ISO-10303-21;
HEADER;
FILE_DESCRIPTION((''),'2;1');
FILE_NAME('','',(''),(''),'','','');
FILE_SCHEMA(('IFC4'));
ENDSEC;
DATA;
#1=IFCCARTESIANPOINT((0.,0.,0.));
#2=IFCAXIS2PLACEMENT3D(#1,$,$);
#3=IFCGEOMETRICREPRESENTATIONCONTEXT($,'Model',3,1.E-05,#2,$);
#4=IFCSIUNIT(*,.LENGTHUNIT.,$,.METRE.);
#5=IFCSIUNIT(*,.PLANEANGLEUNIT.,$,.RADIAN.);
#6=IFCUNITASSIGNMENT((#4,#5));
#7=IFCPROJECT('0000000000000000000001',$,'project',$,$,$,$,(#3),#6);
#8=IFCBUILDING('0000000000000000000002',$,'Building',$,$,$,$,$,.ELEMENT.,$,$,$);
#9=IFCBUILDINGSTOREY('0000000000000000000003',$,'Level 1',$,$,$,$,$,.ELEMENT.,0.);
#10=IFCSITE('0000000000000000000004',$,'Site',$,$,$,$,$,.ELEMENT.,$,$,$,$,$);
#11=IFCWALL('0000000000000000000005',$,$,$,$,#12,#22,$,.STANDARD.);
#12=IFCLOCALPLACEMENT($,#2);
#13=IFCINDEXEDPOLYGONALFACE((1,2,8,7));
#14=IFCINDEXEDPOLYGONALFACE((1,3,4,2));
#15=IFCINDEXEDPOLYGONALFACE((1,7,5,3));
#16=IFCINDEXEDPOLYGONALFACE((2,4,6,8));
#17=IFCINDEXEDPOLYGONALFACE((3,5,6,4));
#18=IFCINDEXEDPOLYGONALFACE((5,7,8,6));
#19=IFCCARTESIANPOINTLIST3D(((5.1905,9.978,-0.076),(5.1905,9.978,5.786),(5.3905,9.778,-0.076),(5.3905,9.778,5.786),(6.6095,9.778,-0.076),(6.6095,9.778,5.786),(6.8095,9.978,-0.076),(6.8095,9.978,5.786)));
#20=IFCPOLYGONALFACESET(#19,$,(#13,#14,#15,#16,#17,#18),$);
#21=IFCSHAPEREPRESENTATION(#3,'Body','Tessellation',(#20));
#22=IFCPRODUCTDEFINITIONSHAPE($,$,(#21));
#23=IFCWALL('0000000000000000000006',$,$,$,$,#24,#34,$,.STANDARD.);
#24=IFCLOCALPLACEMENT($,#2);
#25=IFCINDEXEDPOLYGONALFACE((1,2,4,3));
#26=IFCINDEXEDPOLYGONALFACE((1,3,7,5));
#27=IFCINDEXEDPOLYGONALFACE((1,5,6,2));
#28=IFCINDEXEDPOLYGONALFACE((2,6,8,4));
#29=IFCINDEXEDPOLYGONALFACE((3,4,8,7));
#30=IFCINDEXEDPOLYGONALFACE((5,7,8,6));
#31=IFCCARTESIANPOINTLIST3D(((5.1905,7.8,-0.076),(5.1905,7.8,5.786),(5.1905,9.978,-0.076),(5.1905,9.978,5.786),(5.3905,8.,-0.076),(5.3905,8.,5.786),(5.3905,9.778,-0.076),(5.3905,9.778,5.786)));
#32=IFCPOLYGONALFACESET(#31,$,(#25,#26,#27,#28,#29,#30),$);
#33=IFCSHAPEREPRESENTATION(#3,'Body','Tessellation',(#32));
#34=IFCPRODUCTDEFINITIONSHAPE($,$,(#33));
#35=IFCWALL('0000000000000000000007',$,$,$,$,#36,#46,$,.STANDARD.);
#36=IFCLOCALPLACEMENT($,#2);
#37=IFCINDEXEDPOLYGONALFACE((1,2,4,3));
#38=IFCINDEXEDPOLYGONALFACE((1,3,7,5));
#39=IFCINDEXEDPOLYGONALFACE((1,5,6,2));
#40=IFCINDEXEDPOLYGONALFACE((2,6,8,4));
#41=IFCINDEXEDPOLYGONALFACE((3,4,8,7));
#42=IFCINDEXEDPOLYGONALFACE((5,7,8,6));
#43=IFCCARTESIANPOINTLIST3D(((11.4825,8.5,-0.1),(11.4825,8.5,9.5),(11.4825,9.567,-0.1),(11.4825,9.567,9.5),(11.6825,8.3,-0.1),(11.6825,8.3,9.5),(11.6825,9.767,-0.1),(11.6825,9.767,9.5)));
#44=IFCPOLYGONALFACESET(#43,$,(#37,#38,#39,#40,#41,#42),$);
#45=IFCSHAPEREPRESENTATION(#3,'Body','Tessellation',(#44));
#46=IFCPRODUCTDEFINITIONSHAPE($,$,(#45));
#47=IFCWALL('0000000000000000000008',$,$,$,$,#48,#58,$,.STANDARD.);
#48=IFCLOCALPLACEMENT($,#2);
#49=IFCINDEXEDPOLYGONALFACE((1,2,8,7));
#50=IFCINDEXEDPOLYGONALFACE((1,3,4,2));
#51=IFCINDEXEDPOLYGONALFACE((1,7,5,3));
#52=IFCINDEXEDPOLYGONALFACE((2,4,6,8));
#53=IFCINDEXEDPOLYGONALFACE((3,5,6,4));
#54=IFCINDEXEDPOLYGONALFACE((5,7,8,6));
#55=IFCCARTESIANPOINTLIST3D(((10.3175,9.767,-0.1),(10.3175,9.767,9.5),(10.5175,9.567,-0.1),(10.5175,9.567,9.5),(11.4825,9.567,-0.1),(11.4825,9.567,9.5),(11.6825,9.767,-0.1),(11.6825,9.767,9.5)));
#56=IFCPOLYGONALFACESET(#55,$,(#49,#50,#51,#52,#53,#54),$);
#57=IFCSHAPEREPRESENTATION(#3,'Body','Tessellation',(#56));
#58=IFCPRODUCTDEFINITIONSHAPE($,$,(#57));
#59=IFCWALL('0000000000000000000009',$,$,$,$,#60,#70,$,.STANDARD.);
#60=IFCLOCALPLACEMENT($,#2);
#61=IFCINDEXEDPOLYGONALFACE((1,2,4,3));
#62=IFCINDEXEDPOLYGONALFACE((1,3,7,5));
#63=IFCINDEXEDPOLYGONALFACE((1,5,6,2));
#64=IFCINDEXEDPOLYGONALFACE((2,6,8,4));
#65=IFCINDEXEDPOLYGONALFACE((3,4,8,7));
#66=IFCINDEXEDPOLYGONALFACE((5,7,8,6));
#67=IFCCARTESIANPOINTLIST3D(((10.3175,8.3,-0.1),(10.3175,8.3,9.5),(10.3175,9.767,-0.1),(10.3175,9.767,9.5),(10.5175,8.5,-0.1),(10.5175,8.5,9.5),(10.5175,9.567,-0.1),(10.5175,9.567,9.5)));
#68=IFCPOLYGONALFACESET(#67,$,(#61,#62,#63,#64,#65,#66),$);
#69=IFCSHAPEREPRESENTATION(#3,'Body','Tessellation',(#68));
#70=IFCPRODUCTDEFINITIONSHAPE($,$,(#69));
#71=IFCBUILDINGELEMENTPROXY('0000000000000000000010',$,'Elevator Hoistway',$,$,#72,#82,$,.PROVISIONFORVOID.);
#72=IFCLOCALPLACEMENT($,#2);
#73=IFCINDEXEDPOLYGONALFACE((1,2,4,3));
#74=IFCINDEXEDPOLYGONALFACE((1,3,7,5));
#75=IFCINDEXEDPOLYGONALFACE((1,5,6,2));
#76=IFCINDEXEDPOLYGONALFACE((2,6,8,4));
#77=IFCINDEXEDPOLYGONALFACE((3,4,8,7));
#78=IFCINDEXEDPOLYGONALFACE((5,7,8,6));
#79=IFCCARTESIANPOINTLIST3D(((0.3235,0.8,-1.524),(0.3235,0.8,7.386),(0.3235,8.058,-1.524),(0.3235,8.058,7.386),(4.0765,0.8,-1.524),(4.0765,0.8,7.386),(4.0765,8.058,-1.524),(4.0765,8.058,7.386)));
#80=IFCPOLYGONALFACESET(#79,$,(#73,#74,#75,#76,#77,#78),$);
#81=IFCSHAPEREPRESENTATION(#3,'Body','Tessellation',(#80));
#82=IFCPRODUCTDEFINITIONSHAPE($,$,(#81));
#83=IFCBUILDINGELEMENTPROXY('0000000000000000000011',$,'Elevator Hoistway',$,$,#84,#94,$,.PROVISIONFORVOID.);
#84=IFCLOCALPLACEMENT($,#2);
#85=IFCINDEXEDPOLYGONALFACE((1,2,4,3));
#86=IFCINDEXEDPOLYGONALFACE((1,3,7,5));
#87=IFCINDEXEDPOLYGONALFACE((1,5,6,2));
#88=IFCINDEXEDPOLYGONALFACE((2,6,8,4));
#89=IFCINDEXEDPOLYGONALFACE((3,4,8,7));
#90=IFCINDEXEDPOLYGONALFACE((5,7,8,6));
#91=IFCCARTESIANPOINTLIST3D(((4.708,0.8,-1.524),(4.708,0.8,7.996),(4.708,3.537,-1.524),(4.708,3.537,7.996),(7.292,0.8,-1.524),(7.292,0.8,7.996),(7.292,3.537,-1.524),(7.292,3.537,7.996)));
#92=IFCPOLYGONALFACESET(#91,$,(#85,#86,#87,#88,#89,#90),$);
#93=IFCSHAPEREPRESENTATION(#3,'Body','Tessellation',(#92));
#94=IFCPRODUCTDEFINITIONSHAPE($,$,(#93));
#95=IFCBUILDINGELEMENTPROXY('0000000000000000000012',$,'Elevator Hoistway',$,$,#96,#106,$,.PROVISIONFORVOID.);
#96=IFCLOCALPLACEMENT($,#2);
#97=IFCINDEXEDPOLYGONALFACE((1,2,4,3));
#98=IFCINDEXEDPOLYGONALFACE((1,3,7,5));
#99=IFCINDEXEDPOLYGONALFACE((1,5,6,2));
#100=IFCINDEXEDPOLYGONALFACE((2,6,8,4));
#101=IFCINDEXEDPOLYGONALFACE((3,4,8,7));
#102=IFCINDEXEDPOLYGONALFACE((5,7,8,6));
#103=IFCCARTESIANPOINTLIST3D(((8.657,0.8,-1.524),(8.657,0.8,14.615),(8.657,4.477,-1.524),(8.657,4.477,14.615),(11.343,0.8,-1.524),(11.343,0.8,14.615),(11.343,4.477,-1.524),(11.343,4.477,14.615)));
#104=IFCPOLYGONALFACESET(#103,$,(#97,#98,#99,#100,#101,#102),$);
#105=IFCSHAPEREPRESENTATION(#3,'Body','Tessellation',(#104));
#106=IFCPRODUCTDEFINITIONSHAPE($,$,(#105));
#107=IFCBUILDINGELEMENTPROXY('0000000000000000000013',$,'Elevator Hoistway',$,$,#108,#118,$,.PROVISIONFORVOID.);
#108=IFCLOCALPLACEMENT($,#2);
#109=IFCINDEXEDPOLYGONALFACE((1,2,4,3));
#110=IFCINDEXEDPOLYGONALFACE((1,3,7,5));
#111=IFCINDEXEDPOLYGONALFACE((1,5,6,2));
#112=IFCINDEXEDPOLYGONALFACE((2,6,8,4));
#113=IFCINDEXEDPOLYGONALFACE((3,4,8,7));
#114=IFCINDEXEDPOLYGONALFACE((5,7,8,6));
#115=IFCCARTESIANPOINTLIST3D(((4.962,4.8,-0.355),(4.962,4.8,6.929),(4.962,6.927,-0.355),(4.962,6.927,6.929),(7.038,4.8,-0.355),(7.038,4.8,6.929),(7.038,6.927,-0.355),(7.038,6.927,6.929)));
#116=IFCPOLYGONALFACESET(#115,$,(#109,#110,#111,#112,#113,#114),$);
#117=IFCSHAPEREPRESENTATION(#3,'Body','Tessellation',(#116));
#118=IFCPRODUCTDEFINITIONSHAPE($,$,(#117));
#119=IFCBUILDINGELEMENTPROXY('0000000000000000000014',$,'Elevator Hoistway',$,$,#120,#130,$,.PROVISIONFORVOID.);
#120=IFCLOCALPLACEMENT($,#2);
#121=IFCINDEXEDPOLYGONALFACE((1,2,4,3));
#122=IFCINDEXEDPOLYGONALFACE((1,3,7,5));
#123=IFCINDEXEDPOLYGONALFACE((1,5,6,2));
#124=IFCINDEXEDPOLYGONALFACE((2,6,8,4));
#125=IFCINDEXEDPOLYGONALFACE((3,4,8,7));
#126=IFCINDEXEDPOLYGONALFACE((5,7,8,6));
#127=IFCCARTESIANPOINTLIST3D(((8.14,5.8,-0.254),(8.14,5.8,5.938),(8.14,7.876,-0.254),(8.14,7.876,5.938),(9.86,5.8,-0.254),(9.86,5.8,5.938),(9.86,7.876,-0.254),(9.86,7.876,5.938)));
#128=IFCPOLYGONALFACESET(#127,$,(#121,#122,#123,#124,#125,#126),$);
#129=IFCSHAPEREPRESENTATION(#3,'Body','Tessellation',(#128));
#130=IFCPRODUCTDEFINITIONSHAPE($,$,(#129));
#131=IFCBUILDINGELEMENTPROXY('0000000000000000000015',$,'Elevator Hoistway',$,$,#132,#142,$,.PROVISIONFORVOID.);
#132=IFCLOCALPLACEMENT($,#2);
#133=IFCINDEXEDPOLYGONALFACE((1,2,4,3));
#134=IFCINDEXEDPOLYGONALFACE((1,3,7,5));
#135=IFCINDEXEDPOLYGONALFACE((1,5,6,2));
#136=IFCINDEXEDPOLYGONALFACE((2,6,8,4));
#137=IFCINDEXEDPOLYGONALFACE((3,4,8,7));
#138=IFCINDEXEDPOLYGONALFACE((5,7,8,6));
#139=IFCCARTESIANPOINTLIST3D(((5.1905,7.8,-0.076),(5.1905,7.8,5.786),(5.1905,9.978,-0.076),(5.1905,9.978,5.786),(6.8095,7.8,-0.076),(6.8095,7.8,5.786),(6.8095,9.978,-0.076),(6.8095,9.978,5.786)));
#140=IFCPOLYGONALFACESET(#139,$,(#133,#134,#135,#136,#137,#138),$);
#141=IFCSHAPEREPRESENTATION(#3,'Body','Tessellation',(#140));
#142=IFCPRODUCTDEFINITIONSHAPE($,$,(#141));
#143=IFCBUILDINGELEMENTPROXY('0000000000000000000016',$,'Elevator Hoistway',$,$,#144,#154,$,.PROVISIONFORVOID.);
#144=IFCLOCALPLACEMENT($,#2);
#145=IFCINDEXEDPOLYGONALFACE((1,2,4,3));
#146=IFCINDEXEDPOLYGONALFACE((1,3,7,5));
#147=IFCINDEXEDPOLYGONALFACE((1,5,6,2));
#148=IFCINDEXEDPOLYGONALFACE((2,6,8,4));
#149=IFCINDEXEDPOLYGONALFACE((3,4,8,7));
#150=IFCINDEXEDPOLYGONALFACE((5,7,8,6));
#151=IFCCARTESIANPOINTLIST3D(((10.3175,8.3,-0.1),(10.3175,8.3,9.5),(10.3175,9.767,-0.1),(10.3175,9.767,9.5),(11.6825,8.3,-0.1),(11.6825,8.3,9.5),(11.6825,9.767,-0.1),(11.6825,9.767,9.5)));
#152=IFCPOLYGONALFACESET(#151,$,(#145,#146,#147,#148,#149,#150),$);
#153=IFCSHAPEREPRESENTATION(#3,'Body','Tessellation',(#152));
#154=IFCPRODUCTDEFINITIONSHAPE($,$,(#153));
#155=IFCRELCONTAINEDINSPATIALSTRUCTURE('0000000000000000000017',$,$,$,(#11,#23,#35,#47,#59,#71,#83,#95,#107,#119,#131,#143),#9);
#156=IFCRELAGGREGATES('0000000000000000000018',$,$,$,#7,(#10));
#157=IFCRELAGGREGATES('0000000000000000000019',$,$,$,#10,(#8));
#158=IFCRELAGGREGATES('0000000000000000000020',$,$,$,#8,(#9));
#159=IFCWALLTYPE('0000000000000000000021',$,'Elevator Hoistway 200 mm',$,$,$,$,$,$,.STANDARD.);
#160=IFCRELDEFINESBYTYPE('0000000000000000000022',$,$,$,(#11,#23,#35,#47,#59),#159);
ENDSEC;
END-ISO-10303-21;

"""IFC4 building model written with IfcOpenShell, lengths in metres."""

from ifc_helpers import new_model, si_unit, frame, origin, place, context, project, spatial, polyline, outline, extrude, type_object, element, save


model = new_model("IFC4")

# Units and contexts
model_context = context("Model", 3, precision=1e-05, world=origin())
ifc_project = project(units=[si_unit("LENGTHUNIT", "METRE"), si_unit("PLANEANGLEUNIT", "RADIAN")], contexts=[model_context])

# Site, building, storey
site = spatial("IfcSite", under=ifc_project, Name="Site", CompositionType="ELEMENT")
building = spatial("IfcBuilding", under=site, Name="Building", CompositionType="ELEMENT")
storey = spatial("IfcBuildingStorey", under=building, Name="Level 1", CompositionType="ELEMENT", Elevation=0.0)

# Shared definitions
wall_type = type_object("IfcWallType", Name="Elevator Hoistway 200 mm", PredefinedType="STANDARD")

# Walls
wall_1_placement = place(None, frame((6.7095, 9.878, -0.076), z_axis=(0.0, 0.0, 1.0), x_axis=(-1.0, 0.0, 0.0)))
element("IfcWall", 1, at=wall_1_placement, inside=storey, type_object=wall_type, PredefinedType="STANDARD", context=model_context, shape_type="SweptSolid", body=[
    extrude(outline(polyline([(-0.1, -0.1), (1.519, -0.1), (1.319, 0.1), (0.1, 0.1), (-0.1, -0.1)])), origin(), (0.0, 0.0, 1.0), 5.862),
])
wall_2_placement = place(None, frame((5.2905, 9.878, -0.076), z_axis=(0.0, 0.0, 1.0), x_axis=(0.0, -1.0, 0.0)))
element("IfcWall", 2, at=wall_2_placement, inside=storey, type_object=wall_type, PredefinedType="STANDARD", context=model_context, shape_type="SweptSolid", body=[
    extrude(outline(polyline([(-0.1, -0.1), (2.078, -0.1), (1.878, 0.1), (0.1, 0.1), (-0.1, -0.1)])), origin(), (0.0, 0.0, 1.0), 5.862),
])

# Walls
wall_3_placement = place(None, frame((11.5825, 8.4, -0.1), z_axis=(0.0, 0.0, 1.0), x_axis=(0.0, 1.0, 0.0)))
element("IfcWall", 3, at=wall_3_placement, inside=storey, type_object=wall_type, PredefinedType="STANDARD", context=model_context, shape_type="SweptSolid", body=[
    extrude(outline(polyline([(-0.1, -0.1), (1.367, -0.1), (1.167, 0.1), (0.1, 0.1), (-0.1, -0.1)])), origin(), (0.0, 0.0, 1.0), 9.6),
])
wall_4_placement = place(None, frame((11.5825, 9.667, -0.1), z_axis=(0.0, 0.0, 1.0), x_axis=(-1.0, 0.0, 0.0)))
element("IfcWall", 4, at=wall_4_placement, inside=storey, type_object=wall_type, PredefinedType="STANDARD", context=model_context, shape_type="SweptSolid", body=[
    extrude(outline(polyline([(-0.1, -0.1), (1.265, -0.1), (1.065, 0.1), (0.1, 0.1), (-0.1, -0.1)])), origin(), (0.0, 0.0, 1.0), 9.6),
])
wall_5_placement = place(None, frame((10.4175, 9.667, -0.1), z_axis=(0.0, 0.0, 1.0), x_axis=(0.0, -1.0, 0.0)))
element("IfcWall", 5, at=wall_5_placement, inside=storey, type_object=wall_type, PredefinedType="STANDARD", context=model_context, shape_type="SweptSolid", body=[
    extrude(outline(polyline([(-0.1, -0.1), (1.367, -0.1), (1.167, 0.1), (0.1, 0.1), (-0.1, -0.1)])), origin(), (0.0, 0.0, 1.0), 9.6),
])

# Building element proxies
proxy_1_placement = place(None, frame((0.0, 0.0, 7.386)))
element("IfcBuildingElementProxy", 6, at=proxy_1_placement, inside=storey, Name="Elevator Hoistway", PredefinedType="PROVISIONFORVOID", context=model_context, shape_type="SweptSolid", body=[
    extrude(outline(polyline([(0.3235, 0.8), (4.0765, 0.8), (4.0765, 8.058), (0.3235, 8.058), (0.3235, 0.8)])), origin(), (0.0, 0.0, -1.0), 8.91),
])
proxy_2_placement = place(None, frame((0.0, 0.0, 7.996)))
element("IfcBuildingElementProxy", 7, at=proxy_2_placement, inside=storey, Name="Elevator Hoistway", PredefinedType="PROVISIONFORVOID", context=model_context, shape_type="SweptSolid", body=[
    extrude(outline(polyline([(4.708, 0.8), (7.292, 0.8), (7.292, 3.537), (4.708, 3.537), (4.708, 0.8)])), origin(), (0.0, 0.0, -1.0), 9.52),
])
proxy_3_placement = place(None, frame((0.0, 0.0, 14.615)))
element("IfcBuildingElementProxy", 8, at=proxy_3_placement, inside=storey, Name="Elevator Hoistway", PredefinedType="PROVISIONFORVOID", context=model_context, shape_type="SweptSolid", body=[
    extrude(outline(polyline([(8.657, 0.8), (11.343, 0.8), (11.343, 4.477), (8.657, 4.477), (8.657, 0.8)])), origin(), (0.0, 0.0, -1.0), 16.139),
])
proxy_4_placement = place(None, frame((0.0, 0.0, 6.929)))
element("IfcBuildingElementProxy", 9, at=proxy_4_placement, inside=storey, Name="Elevator Hoistway", PredefinedType="PROVISIONFORVOID", context=model_context, shape_type="SweptSolid", body=[
    extrude(outline(polyline([(4.962, 4.8), (7.038, 4.8), (7.038, 6.927), (4.962, 6.927), (4.962, 4.8)])), origin(), (0.0, 0.0, -1.0), 7.284),
])
proxy_5_placement = place(None, frame((0.0, 0.0, 5.938)))
element("IfcBuildingElementProxy", 10, at=proxy_5_placement, inside=storey, Name="Elevator Hoistway", PredefinedType="PROVISIONFORVOID", context=model_context, shape_type="SweptSolid", body=[
    extrude(outline(polyline([(8.14, 5.8), (9.86, 5.8), (9.86, 7.876), (8.14, 7.876), (8.14, 5.8)])), origin(), (0.0, 0.0, -1.0), 6.192),
])
proxy_6_placement = place(None, frame((0.0, 0.0, 5.786)))
element("IfcBuildingElementProxy", 11, at=proxy_6_placement, inside=storey, Name="Elevator Hoistway", PredefinedType="PROVISIONFORVOID", context=model_context, shape_type="SweptSolid", body=[
    extrude(outline(polyline([(5.1905, 7.8), (6.8095, 7.8), (6.8095, 9.978), (5.1905, 9.978), (5.1905, 7.8)])), origin(), (0.0, 0.0, -1.0), 5.862),
])
proxy_7_placement = place(None, frame((0.0, 0.0, 9.5)))
element("IfcBuildingElementProxy", 12, at=proxy_7_placement, inside=storey, Name="Elevator Hoistway", PredefinedType="PROVISIONFORVOID", context=model_context, shape_type="SweptSolid", body=[
    extrude(outline(polyline([(10.3175, 8.3), (11.6825, 8.3), (11.6825, 9.767), (10.3175, 9.767), (10.3175, 8.3)])), origin(), (0.0, 0.0, -1.0), 9.6),
])

save(model, "model.ifc")
